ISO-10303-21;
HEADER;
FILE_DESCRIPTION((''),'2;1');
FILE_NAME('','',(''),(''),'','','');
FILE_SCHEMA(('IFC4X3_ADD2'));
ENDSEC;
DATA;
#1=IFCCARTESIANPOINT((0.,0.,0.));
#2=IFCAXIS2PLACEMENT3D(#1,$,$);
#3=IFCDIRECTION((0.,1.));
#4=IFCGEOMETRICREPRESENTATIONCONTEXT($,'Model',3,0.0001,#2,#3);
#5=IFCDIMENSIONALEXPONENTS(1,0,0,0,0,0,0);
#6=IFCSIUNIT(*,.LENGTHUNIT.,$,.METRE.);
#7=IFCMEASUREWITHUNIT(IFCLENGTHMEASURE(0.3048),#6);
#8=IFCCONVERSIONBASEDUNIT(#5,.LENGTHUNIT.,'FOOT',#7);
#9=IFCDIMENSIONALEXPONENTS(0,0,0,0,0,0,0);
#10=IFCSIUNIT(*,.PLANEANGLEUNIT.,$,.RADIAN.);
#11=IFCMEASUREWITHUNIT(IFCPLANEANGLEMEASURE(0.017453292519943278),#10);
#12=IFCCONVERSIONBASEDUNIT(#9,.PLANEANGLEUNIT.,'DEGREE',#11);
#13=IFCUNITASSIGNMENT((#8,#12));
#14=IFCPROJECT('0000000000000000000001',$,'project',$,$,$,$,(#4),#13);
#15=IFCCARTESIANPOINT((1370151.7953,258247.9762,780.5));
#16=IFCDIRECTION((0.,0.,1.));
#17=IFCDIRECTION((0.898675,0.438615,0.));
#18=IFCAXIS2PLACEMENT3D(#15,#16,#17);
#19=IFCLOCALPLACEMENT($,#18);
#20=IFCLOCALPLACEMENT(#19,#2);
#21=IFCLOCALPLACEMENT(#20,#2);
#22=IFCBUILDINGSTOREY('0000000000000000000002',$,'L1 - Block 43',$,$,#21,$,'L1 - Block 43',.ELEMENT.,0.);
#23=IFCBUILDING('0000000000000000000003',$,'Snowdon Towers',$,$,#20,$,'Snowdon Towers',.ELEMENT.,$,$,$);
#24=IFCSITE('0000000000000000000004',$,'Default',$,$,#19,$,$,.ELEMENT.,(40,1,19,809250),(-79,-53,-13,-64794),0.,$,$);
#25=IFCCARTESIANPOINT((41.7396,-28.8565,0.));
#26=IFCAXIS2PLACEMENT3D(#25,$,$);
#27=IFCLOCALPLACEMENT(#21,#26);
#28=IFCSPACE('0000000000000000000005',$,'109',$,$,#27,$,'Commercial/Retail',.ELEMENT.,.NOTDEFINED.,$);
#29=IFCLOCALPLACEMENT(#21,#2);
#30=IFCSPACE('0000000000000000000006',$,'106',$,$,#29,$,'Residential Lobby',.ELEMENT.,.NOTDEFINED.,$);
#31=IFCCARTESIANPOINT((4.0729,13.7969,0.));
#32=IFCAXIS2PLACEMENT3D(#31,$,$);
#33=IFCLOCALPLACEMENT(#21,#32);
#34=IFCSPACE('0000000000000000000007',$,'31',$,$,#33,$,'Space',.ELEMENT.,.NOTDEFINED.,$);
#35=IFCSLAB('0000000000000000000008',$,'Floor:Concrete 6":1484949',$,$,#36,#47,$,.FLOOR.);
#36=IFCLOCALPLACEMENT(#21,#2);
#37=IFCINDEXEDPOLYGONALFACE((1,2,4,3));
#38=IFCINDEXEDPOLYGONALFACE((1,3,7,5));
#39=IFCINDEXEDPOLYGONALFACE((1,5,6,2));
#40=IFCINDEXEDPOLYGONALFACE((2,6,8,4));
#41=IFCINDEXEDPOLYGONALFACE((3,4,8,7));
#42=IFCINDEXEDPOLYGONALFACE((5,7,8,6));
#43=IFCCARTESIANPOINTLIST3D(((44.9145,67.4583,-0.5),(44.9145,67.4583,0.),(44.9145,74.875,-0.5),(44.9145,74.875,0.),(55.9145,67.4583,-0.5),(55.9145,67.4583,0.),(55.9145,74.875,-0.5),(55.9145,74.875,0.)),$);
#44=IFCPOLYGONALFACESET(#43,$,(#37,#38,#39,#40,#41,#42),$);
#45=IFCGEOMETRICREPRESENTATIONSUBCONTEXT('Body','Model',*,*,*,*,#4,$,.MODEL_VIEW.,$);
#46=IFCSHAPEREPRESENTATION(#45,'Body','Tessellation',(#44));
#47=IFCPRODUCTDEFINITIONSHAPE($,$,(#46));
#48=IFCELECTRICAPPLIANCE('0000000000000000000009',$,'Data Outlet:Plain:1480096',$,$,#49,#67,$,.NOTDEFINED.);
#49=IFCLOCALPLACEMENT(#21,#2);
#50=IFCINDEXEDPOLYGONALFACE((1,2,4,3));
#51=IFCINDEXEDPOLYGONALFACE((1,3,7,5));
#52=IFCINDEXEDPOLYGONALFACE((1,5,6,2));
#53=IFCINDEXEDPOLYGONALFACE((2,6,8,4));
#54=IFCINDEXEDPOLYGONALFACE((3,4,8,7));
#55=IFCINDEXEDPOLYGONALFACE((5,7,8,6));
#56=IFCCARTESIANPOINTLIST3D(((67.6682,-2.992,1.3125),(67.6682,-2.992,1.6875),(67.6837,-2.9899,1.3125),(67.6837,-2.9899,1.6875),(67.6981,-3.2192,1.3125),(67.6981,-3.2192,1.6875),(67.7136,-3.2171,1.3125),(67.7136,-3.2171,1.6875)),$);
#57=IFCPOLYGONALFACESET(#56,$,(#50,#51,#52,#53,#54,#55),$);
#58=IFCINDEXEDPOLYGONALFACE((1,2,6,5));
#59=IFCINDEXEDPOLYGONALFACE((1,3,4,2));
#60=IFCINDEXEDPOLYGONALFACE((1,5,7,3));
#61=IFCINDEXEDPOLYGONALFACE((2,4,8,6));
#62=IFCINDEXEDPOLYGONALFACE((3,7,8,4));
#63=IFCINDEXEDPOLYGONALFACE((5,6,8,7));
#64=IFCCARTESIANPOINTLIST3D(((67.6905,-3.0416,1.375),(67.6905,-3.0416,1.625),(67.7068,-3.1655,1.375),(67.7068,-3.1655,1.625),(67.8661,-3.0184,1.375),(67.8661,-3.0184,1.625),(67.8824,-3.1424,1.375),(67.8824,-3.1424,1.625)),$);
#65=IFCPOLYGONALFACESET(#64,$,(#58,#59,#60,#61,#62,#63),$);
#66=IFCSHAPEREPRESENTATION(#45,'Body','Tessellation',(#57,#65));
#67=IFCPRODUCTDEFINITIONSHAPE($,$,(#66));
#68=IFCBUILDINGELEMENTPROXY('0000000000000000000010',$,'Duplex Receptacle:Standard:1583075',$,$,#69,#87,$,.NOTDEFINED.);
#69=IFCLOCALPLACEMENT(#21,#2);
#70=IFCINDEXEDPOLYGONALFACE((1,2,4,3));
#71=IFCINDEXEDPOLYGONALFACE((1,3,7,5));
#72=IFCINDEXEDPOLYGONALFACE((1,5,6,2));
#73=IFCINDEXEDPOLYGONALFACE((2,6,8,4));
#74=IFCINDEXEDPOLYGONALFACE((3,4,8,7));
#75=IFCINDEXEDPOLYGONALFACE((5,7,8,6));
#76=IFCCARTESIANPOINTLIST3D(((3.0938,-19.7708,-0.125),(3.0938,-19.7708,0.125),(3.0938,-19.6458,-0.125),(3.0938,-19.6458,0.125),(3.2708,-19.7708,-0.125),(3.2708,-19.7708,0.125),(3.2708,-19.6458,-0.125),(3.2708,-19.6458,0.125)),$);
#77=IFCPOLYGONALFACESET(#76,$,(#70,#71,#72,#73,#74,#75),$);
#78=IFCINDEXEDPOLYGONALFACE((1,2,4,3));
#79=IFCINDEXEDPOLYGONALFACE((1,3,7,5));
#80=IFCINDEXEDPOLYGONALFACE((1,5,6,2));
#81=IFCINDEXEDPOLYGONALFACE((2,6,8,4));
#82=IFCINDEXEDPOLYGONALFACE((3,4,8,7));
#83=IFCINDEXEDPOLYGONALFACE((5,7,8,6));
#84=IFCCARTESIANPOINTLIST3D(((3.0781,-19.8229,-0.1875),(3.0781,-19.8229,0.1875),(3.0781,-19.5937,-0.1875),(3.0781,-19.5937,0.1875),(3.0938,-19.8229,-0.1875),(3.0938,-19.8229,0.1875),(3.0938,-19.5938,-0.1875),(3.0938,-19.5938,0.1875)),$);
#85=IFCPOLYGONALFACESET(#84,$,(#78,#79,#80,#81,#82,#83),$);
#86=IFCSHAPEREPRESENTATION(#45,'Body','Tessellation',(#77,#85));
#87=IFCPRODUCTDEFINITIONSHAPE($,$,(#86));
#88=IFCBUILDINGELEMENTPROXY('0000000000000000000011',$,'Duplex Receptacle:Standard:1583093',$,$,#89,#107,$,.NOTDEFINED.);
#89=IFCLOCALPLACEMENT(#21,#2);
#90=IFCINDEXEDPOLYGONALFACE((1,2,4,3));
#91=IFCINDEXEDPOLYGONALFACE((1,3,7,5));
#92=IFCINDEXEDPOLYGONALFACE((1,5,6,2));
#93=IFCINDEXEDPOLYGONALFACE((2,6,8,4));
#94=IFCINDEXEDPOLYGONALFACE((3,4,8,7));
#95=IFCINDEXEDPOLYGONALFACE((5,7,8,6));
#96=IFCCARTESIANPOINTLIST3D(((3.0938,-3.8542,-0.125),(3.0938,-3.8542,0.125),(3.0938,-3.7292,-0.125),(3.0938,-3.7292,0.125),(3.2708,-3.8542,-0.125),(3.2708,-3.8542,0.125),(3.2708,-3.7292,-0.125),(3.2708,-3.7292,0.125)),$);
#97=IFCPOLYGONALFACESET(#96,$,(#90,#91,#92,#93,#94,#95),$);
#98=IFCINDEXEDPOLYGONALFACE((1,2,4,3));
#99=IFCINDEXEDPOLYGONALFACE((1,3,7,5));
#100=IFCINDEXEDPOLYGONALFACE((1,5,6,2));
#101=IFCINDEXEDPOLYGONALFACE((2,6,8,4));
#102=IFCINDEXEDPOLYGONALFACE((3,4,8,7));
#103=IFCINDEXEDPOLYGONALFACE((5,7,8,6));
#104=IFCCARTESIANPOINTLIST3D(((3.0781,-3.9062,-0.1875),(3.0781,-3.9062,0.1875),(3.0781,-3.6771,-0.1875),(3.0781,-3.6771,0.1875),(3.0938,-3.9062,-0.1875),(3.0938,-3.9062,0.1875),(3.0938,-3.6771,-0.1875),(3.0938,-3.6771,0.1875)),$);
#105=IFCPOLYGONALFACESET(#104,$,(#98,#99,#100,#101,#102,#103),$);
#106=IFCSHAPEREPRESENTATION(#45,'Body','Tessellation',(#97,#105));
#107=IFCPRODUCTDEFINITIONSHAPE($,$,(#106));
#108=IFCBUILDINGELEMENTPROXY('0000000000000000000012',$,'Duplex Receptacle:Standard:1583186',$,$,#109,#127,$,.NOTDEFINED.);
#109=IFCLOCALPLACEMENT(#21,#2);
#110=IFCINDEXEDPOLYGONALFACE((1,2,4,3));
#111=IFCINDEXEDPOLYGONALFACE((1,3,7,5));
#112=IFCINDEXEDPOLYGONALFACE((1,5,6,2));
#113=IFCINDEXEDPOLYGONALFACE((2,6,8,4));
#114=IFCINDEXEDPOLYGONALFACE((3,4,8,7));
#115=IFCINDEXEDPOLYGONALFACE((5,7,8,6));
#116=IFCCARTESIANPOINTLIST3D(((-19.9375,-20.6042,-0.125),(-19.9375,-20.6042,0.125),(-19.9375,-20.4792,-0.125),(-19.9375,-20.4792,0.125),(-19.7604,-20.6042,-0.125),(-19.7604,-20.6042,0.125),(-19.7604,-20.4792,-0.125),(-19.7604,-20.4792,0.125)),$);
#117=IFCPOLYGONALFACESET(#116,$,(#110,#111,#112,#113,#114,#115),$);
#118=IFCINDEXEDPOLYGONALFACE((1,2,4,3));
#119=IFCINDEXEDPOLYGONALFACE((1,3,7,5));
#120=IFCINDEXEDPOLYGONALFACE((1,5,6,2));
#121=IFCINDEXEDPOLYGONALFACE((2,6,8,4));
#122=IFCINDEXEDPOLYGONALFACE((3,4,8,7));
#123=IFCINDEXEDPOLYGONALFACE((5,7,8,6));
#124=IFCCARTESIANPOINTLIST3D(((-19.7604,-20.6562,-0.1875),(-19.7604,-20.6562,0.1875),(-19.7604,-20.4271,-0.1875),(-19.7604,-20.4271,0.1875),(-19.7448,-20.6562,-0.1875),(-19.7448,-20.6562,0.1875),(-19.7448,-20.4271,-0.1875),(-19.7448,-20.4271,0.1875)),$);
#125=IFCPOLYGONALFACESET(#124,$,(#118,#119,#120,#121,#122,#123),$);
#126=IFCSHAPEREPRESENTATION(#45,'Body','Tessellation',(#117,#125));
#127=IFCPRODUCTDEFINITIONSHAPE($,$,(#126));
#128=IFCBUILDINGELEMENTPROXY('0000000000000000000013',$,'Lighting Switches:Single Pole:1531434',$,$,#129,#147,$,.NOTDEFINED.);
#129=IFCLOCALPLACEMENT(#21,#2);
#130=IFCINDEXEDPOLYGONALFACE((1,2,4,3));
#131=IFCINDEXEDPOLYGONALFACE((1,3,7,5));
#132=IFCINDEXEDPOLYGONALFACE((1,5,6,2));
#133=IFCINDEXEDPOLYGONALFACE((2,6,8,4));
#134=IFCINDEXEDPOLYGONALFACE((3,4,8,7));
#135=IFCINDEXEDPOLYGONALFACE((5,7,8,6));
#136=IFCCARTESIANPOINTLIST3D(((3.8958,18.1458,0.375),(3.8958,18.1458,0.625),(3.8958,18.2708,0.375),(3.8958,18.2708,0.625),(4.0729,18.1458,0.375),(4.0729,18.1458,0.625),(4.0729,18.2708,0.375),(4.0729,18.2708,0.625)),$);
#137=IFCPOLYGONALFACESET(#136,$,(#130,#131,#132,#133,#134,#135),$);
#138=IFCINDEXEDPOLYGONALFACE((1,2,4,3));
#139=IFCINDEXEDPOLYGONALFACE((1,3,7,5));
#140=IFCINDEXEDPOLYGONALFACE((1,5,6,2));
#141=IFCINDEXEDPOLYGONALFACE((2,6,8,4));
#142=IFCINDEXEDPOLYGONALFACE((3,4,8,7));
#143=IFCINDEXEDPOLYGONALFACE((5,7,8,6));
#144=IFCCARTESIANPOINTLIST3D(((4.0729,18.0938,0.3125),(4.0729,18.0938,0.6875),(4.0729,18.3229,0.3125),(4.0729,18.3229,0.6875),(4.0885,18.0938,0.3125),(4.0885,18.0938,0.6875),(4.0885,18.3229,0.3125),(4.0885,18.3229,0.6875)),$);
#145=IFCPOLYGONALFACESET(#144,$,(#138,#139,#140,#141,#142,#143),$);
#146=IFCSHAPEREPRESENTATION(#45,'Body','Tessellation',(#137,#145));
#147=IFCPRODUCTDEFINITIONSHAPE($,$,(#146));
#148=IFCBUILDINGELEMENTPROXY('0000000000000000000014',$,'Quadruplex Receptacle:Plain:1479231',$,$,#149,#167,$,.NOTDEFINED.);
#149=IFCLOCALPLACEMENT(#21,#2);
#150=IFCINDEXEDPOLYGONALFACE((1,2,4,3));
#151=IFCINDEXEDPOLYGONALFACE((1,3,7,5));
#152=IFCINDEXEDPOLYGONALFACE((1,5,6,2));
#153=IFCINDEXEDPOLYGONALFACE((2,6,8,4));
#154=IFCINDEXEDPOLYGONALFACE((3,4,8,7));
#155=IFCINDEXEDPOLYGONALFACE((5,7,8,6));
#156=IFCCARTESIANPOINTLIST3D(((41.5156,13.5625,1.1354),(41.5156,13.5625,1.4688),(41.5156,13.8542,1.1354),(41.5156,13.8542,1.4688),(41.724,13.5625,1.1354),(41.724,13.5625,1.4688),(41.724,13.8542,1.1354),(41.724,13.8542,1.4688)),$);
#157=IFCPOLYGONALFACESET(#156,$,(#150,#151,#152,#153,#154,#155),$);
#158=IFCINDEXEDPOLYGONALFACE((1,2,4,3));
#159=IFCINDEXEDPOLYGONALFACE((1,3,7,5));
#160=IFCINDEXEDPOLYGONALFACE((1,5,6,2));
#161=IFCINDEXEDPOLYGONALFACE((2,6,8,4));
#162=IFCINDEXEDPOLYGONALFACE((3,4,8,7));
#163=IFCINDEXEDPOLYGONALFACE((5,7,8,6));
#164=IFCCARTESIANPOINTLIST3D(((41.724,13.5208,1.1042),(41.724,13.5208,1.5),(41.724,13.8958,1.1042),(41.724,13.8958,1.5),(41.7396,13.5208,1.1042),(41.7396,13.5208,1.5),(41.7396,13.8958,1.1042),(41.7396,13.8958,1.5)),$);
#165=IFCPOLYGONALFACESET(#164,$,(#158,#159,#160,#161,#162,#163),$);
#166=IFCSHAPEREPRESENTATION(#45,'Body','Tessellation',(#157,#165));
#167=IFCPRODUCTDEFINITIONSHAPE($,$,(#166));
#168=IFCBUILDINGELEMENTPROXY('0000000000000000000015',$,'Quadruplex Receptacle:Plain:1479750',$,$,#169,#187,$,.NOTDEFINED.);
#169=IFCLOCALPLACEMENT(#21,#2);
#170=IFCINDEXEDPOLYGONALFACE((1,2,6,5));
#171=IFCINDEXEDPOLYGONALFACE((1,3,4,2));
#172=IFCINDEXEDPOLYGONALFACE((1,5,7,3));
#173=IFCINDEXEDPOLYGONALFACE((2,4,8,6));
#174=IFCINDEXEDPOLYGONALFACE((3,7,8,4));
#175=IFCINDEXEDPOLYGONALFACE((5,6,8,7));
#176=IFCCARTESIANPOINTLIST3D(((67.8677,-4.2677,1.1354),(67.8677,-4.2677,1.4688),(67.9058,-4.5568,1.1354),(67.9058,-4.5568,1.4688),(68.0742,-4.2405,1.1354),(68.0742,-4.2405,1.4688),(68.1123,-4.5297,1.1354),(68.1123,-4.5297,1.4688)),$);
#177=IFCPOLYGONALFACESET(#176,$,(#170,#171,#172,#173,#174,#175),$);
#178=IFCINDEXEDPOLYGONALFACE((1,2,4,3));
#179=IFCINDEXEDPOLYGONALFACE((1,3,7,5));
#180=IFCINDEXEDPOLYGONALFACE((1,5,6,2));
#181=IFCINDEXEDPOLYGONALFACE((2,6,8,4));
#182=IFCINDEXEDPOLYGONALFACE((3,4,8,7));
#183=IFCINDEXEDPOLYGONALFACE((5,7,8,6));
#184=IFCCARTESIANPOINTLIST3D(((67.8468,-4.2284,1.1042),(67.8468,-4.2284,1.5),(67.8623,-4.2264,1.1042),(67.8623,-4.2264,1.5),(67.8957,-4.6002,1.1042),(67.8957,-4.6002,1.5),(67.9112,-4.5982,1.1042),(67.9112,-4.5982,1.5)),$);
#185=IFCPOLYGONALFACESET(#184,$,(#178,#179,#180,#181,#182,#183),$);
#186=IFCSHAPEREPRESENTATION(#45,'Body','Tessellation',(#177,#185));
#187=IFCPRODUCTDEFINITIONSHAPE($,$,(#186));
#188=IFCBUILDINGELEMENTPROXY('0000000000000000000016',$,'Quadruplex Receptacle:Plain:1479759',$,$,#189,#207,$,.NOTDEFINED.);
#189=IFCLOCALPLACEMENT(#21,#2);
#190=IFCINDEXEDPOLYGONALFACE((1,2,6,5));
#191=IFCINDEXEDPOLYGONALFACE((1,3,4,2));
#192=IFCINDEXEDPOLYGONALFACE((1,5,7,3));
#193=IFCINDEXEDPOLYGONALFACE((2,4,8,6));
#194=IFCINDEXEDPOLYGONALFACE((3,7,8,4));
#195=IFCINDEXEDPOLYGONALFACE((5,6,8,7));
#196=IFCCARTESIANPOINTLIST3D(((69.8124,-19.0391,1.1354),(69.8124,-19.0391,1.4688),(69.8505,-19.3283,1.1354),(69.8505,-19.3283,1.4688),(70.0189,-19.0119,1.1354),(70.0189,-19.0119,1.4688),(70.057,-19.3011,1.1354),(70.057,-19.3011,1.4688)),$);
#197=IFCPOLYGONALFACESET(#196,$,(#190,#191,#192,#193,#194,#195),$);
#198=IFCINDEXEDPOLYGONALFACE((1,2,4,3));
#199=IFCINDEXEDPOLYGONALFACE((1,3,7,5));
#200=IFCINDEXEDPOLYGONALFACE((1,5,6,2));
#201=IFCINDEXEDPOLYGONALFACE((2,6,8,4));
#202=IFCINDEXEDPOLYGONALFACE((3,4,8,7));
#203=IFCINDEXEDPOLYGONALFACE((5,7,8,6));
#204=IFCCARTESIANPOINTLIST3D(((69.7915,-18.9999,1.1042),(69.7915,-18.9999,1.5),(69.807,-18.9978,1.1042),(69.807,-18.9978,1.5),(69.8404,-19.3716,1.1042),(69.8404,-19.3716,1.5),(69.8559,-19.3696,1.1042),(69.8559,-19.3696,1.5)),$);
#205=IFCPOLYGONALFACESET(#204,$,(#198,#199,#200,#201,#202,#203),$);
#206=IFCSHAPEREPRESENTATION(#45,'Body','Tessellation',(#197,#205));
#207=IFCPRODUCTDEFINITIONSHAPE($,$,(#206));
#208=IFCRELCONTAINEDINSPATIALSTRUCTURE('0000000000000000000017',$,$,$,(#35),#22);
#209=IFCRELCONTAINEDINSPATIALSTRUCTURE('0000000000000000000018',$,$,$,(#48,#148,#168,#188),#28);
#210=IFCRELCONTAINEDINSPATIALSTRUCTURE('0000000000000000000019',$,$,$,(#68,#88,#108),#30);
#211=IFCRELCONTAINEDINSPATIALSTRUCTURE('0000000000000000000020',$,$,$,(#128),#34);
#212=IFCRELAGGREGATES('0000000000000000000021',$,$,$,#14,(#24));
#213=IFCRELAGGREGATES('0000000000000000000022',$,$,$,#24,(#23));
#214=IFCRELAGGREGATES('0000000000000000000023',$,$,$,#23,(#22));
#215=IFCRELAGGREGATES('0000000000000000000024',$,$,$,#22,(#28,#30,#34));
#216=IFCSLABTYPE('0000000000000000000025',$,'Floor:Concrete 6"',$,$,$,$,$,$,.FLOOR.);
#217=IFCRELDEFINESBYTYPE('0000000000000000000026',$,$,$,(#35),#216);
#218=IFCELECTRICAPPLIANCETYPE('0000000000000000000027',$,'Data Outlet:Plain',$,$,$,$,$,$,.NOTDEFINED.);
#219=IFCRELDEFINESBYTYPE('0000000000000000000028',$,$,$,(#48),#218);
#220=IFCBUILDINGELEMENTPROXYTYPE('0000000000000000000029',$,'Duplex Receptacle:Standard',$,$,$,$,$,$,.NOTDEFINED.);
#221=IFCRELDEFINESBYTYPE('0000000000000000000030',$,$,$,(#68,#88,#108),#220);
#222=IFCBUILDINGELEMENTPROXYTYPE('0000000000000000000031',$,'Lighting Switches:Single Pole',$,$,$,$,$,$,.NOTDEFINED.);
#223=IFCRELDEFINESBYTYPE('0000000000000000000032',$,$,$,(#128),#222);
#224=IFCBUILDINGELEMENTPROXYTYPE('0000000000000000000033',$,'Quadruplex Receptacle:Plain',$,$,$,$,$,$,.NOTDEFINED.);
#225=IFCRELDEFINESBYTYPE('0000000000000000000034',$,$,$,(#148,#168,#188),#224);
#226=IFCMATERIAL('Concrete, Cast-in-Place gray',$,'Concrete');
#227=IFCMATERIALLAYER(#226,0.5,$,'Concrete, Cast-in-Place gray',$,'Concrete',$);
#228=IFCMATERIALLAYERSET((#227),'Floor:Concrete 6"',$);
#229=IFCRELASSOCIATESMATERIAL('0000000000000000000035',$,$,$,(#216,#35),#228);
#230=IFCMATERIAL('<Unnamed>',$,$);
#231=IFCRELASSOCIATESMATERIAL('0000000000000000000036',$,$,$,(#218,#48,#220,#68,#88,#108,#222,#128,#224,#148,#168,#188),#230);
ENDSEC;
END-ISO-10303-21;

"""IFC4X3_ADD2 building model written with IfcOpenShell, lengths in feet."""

from ifc_helpers import new_model, entity, si_unit, converted_unit, direction, frame, frame_2d, origin, origin_2d_with_axis, place, context, subcontext, project, spatial, rectangle, extrude, source, transform, mapped, material, layer, layer_set, layer_usage, type_object, type_shapes, element, save


model = new_model("IFC4X3_ADD2")

# Units and contexts
model_context = context("Model", 3, precision=0.0001, world=origin(), true_north=direction((0.0, 1.0)))
body_context = subcontext(model_context, "Body", "Model", "MODEL_VIEW")
ifc_project = project(units=[converted_unit("LENGTHUNIT", "FOOT", entity("IfcLengthMeasure", 0.3048), si_unit("LENGTHUNIT", "METRE"), dimensions=[1, 0, 0, 0, 0, 0, 0]), converted_unit("PLANEANGLEUNIT", "DEGREE", entity("IfcPlaneAngleMeasure", 0.017453292519943278), si_unit("PLANEANGLEUNIT", "RADIAN"), dimensions=[0, 0, 0, 0, 0, 0, 0])], contexts=[model_context])

# Site, building, storey
site_placement = place(None, frame((1370151.7953, 258247.9762, 780.5), z_axis=(0.0, 0.0, 1.0), x_axis=(0.898675, 0.438615, 0.0)))
site = spatial("IfcSite", under=ifc_project, at=site_placement, Name="Default", CompositionType="ELEMENT", RefLatitude=(40, 1, 19, 809250), RefLongitude=(-79, -53, -13, -64794), RefElevation=0.0)
building_placement = place(site_placement, origin())
building = spatial("IfcBuilding", under=site, at=building_placement, Name="Snowdon Towers", LongName="Snowdon Towers", CompositionType="ELEMENT")
storey_placement = place(building_placement, origin())
storey = spatial("IfcBuildingStorey", under=building, at=storey_placement, Name="L1 - Block 43", LongName="L1 - Block 43", CompositionType="ELEMENT", Elevation=0.0)

# Slab
ifc_material_1 = material(Name="Concrete, Cast-in-Place gray", Category="Concrete")
ifc_layer = layer(ifc_material_1, 0.5, Name="Concrete, Cast-in-Place gray", Category="Concrete")
ifc_layer_set = layer_set([ifc_layer], Name="Floor:Concrete 6\"")
ifc_layer_usage = layer_usage(ifc_layer_set, "AXIS3", "POSITIVE", 0.0)
slab_type = type_object("IfcSlabType", Name="Floor:Concrete 6\"", PredefinedType="FLOOR", material=ifc_layer_set)
slab_placement = place(storey_placement, origin())
element("IfcSlab", 1, at=slab_placement, inside=storey, type_object=slab_type, material=ifc_layer_usage, Name="Floor:Concrete 6\":1484949", PredefinedType="FLOOR", context=body_context, shape_type="SweptSolid", body=[
    extrude(rectangle(XDim=7.4167, YDim=11.0, at=frame_2d((0.0, 0.0), x_axis=(1.0, 0.0))), frame((50.4145, 71.1667, 0.0), z_axis=(0.0, 0.0, -1.0), x_axis=(0.0, 1.0, 0.0)), (0.0, 0.0, 1.0), 0.5),
])

# Shared definitions
space_1_placement = place(storey_placement, frame((41.7396, -28.8565, 0.0)))
space_1 = spatial("IfcSpace", under=storey, at=space_1_placement, Name="109", LongName="Commercial/Retail", CompositionType="ELEMENT", PredefinedType="NOTDEFINED")

# Electric appliance
ifc_material_2 = material(Name="<Unnamed>")
electric_appliance_type = type_object("IfcElectricApplianceType", Name="Data Outlet:Plain", PredefinedType="NOTDEFINED", material=ifc_material_2)
shared_shape_1 = source(origin(), body_context, "Body", "SweptSolid", [
    extrude(rectangle(XDim=0.2292, YDim=0.375, at=frame_2d((0.0, 0.0), x_axis=(1.0, 0.0))), frame((0.0, 0.0, 0.0), z_axis=(0.0, 0.0, 1.0), x_axis=(-1.0, 0.0, 0.0)), (0.0, 0.0, 1.0), 0.0156),
    extrude(rectangle(XDim=0.125, YDim=0.25, at=frame_2d((0.0, 0.0), x_axis=(1.0, 0.0))), frame((0.0, 0.0, -0.1771), z_axis=(0.0, 0.0, 1.0), x_axis=(-1.0, 0.0, 0.0)), (0.0, 0.0, 1.0), 0.1771),
])
type_shapes(electric_appliance_type, [shared_shape_1])
for number, where, z_axis, x_axis, name in (
    (2, (25.9591, 25.753, 1.5), (-0.991445, -0.130526, 0.0), (0.130526, -0.991445, 0.0), "Data Outlet:Plain:1480096"),
):
    element("IfcElectricAppliance", number, at=place(space_1_placement, frame(where, z_axis=z_axis, x_axis=x_axis)), inside=space_1, type_object=electric_appliance_type, material=ifc_material_2, Name=name, PredefinedType="NOTDEFINED", context=body_context, shape_type="MappedRepresentation", body=[
        mapped(shared_shape_1, transform((0.0, 0.0, 0.0), scale=1.0)),
    ])

# Shared definitions
space_2_placement = place(storey_placement, origin())
space_2 = spatial("IfcSpace", under=storey, at=space_2_placement, Name="106", LongName="Residential Lobby", CompositionType="ELEMENT", PredefinedType="NOTDEFINED")

# Shared definitions
building_element_proxy_type_1 = type_object("IfcBuildingElementProxyType", Name="Duplex Receptacle:Standard", PredefinedType="NOTDEFINED", material=ifc_material_2)
shared_shape_2 = source(origin(), body_context, "Body", "SweptSolid", [
    extrude(rectangle(XDim=0.125, YDim=0.25, at=origin_2d_with_axis()), frame((0.0, 0.0, -0.1771), z_axis=(0.0, 0.0, 1.0), x_axis=(-1.0, 0.0, 0.0)), (0.0, 0.0, 1.0), 0.1771),
    extrude(rectangle(XDim=0.2292, YDim=0.375, at=frame_2d((0.0, 0.0), x_axis=(1.0, 0.0))), frame((0.0, 0.0, 0.0), z_axis=(0.0, 0.0, 1.0), x_axis=(-1.0, 0.0, 0.0)), (0.0, 0.0, 1.0), 0.0156),
])
type_shapes(building_element_proxy_type_1, [shared_shape_2])

# Building element proxies
for number, where, z_axis, x_axis, name in (
    (3, (3.0938, -19.7083, 0.0), (-1.0, 0.0, 0.0), (0.0, 1.0, 0.0), "Duplex Receptacle:Standard:1583075"),
    (4, (3.0938, -3.7917, 0.0), (-1.0, 0.0, 0.0), (0.0, -1.0, 0.0), "Duplex Receptacle:Standard:1583093"),
    (5, (-19.7604, -20.5417, 0.0), (1.0, 0.0, 0.0), (0.0, 1.0, 0.0), "Duplex Receptacle:Standard:1583186"),
):
    element("IfcBuildingElementProxy", number, at=place(space_2_placement, frame(where, z_axis=z_axis, x_axis=x_axis)), inside=space_2, type_object=building_element_proxy_type_1, material=ifc_material_2, Name=name, PredefinedType="NOTDEFINED", context=body_context, shape_type="MappedRepresentation", body=[
        mapped(shared_shape_2, transform((0.0, 0.0, 0.0), scale=1.0)),
    ])

# Shared definitions
space_3_placement = place(storey_placement, frame((4.0729, 13.7969, 0.0)))
space_3 = spatial("IfcSpace", under=storey, at=space_3_placement, Name="31", LongName="Space", CompositionType="ELEMENT", PredefinedType="NOTDEFINED")

# Building element proxies
building_element_proxy_type_2 = type_object("IfcBuildingElementProxyType", Name="Lighting Switches:Single Pole", PredefinedType="NOTDEFINED", material=ifc_material_2)
shared_shape_3 = source(origin(), body_context, "Body", "SweptSolid", [
    extrude(rectangle(XDim=0.125, YDim=0.25, at=origin_2d_with_axis()), frame((0.0, 0.0, -0.1771), z_axis=(0.0, 0.0, 1.0), x_axis=(-1.0, 0.0, 0.0)), (0.0, 0.0, 1.0), 0.1771),
    extrude(rectangle(XDim=0.2292, YDim=0.375, at=frame_2d((0.0, 0.0), x_axis=(1.0, 0.0))), frame((0.0, 0.0, 0.0), z_axis=(0.0, 0.0, 1.0), x_axis=(-1.0, 0.0, 0.0)), (0.0, 0.0, 1.0), 0.0156),
])
type_shapes(building_element_proxy_type_2, [shared_shape_3])
proxy_1_placement = place(space_3_placement, frame((0.0, 4.4115, 0.5), z_axis=(1.0, 0.0, 0.0), x_axis=(0.0, 1.0, 0.0)))
element("IfcBuildingElementProxy", 6, at=proxy_1_placement, inside=space_3, type_object=building_element_proxy_type_2, material=ifc_material_2, Name="Lighting Switches:Single Pole:1531434", PredefinedType="NOTDEFINED", context=body_context, shape_type="MappedRepresentation", body=[
    mapped(shared_shape_3, transform((0.0, 0.0, 0.0), scale=1.0)),
])
building_element_proxy_type_3 = type_object("IfcBuildingElementProxyType", Name="Quadruplex Receptacle:Plain", PredefinedType="NOTDEFINED", material=ifc_material_2)
shared_shape_4 = source(origin(), body_context, "Body", "SweptSolid", [
    extrude(rectangle(XDim=0.2917, YDim=0.3333, at=frame_2d((0.0, 0.0), x_axis=(1.0, 0.0))), frame((0.0, -0.1979, -0.224), z_axis=(0.0, 0.0, 1.0), x_axis=(-1.0, 0.0, 0.0)), (0.0, 0.0, 1.0), 0.2083),
    extrude(rectangle(XDim=0.375, YDim=0.3958, at=origin_2d_with_axis()), frame((0.0, -0.1979, -0.0156), z_axis=(0.0, 0.0, 1.0), x_axis=(-1.0, 0.0, 0.0)), (0.0, 0.0, 1.0), 0.0156),
])
type_shapes(building_element_proxy_type_3, [shared_shape_4])
for number, where, z_axis, x_axis, name in (
    (7, (0.0, 42.5648, 1.5), (1.0, 0.0, 0.0), (0.0, 1.0, 0.0), "Quadruplex Receptacle:Plain:1479231"),
    (8, (26.1317, 24.4422, 1.5), (-0.991445, -0.130526, 0.0), (0.130526, -0.991445, 0.0), "Quadruplex Receptacle:Plain:1479750"),
    (9, (28.0764, 9.6707, 1.5), (-0.991445, -0.130526, 0.0), (0.130526, -0.991445, 0.0), "Quadruplex Receptacle:Plain:1479759"),
):
    element("IfcBuildingElementProxy", number, at=place(space_1_placement, frame(where, z_axis=z_axis, x_axis=x_axis)), inside=space_1, type_object=building_element_proxy_type_3, material=ifc_material_2, Name=name, PredefinedType="NOTDEFINED", context=body_context, shape_type="MappedRepresentation", body=[
        mapped(shared_shape_4, transform((0.0, 0.0, 0.0), scale=1.0)),
    ])

save(model, "model.ifc")
